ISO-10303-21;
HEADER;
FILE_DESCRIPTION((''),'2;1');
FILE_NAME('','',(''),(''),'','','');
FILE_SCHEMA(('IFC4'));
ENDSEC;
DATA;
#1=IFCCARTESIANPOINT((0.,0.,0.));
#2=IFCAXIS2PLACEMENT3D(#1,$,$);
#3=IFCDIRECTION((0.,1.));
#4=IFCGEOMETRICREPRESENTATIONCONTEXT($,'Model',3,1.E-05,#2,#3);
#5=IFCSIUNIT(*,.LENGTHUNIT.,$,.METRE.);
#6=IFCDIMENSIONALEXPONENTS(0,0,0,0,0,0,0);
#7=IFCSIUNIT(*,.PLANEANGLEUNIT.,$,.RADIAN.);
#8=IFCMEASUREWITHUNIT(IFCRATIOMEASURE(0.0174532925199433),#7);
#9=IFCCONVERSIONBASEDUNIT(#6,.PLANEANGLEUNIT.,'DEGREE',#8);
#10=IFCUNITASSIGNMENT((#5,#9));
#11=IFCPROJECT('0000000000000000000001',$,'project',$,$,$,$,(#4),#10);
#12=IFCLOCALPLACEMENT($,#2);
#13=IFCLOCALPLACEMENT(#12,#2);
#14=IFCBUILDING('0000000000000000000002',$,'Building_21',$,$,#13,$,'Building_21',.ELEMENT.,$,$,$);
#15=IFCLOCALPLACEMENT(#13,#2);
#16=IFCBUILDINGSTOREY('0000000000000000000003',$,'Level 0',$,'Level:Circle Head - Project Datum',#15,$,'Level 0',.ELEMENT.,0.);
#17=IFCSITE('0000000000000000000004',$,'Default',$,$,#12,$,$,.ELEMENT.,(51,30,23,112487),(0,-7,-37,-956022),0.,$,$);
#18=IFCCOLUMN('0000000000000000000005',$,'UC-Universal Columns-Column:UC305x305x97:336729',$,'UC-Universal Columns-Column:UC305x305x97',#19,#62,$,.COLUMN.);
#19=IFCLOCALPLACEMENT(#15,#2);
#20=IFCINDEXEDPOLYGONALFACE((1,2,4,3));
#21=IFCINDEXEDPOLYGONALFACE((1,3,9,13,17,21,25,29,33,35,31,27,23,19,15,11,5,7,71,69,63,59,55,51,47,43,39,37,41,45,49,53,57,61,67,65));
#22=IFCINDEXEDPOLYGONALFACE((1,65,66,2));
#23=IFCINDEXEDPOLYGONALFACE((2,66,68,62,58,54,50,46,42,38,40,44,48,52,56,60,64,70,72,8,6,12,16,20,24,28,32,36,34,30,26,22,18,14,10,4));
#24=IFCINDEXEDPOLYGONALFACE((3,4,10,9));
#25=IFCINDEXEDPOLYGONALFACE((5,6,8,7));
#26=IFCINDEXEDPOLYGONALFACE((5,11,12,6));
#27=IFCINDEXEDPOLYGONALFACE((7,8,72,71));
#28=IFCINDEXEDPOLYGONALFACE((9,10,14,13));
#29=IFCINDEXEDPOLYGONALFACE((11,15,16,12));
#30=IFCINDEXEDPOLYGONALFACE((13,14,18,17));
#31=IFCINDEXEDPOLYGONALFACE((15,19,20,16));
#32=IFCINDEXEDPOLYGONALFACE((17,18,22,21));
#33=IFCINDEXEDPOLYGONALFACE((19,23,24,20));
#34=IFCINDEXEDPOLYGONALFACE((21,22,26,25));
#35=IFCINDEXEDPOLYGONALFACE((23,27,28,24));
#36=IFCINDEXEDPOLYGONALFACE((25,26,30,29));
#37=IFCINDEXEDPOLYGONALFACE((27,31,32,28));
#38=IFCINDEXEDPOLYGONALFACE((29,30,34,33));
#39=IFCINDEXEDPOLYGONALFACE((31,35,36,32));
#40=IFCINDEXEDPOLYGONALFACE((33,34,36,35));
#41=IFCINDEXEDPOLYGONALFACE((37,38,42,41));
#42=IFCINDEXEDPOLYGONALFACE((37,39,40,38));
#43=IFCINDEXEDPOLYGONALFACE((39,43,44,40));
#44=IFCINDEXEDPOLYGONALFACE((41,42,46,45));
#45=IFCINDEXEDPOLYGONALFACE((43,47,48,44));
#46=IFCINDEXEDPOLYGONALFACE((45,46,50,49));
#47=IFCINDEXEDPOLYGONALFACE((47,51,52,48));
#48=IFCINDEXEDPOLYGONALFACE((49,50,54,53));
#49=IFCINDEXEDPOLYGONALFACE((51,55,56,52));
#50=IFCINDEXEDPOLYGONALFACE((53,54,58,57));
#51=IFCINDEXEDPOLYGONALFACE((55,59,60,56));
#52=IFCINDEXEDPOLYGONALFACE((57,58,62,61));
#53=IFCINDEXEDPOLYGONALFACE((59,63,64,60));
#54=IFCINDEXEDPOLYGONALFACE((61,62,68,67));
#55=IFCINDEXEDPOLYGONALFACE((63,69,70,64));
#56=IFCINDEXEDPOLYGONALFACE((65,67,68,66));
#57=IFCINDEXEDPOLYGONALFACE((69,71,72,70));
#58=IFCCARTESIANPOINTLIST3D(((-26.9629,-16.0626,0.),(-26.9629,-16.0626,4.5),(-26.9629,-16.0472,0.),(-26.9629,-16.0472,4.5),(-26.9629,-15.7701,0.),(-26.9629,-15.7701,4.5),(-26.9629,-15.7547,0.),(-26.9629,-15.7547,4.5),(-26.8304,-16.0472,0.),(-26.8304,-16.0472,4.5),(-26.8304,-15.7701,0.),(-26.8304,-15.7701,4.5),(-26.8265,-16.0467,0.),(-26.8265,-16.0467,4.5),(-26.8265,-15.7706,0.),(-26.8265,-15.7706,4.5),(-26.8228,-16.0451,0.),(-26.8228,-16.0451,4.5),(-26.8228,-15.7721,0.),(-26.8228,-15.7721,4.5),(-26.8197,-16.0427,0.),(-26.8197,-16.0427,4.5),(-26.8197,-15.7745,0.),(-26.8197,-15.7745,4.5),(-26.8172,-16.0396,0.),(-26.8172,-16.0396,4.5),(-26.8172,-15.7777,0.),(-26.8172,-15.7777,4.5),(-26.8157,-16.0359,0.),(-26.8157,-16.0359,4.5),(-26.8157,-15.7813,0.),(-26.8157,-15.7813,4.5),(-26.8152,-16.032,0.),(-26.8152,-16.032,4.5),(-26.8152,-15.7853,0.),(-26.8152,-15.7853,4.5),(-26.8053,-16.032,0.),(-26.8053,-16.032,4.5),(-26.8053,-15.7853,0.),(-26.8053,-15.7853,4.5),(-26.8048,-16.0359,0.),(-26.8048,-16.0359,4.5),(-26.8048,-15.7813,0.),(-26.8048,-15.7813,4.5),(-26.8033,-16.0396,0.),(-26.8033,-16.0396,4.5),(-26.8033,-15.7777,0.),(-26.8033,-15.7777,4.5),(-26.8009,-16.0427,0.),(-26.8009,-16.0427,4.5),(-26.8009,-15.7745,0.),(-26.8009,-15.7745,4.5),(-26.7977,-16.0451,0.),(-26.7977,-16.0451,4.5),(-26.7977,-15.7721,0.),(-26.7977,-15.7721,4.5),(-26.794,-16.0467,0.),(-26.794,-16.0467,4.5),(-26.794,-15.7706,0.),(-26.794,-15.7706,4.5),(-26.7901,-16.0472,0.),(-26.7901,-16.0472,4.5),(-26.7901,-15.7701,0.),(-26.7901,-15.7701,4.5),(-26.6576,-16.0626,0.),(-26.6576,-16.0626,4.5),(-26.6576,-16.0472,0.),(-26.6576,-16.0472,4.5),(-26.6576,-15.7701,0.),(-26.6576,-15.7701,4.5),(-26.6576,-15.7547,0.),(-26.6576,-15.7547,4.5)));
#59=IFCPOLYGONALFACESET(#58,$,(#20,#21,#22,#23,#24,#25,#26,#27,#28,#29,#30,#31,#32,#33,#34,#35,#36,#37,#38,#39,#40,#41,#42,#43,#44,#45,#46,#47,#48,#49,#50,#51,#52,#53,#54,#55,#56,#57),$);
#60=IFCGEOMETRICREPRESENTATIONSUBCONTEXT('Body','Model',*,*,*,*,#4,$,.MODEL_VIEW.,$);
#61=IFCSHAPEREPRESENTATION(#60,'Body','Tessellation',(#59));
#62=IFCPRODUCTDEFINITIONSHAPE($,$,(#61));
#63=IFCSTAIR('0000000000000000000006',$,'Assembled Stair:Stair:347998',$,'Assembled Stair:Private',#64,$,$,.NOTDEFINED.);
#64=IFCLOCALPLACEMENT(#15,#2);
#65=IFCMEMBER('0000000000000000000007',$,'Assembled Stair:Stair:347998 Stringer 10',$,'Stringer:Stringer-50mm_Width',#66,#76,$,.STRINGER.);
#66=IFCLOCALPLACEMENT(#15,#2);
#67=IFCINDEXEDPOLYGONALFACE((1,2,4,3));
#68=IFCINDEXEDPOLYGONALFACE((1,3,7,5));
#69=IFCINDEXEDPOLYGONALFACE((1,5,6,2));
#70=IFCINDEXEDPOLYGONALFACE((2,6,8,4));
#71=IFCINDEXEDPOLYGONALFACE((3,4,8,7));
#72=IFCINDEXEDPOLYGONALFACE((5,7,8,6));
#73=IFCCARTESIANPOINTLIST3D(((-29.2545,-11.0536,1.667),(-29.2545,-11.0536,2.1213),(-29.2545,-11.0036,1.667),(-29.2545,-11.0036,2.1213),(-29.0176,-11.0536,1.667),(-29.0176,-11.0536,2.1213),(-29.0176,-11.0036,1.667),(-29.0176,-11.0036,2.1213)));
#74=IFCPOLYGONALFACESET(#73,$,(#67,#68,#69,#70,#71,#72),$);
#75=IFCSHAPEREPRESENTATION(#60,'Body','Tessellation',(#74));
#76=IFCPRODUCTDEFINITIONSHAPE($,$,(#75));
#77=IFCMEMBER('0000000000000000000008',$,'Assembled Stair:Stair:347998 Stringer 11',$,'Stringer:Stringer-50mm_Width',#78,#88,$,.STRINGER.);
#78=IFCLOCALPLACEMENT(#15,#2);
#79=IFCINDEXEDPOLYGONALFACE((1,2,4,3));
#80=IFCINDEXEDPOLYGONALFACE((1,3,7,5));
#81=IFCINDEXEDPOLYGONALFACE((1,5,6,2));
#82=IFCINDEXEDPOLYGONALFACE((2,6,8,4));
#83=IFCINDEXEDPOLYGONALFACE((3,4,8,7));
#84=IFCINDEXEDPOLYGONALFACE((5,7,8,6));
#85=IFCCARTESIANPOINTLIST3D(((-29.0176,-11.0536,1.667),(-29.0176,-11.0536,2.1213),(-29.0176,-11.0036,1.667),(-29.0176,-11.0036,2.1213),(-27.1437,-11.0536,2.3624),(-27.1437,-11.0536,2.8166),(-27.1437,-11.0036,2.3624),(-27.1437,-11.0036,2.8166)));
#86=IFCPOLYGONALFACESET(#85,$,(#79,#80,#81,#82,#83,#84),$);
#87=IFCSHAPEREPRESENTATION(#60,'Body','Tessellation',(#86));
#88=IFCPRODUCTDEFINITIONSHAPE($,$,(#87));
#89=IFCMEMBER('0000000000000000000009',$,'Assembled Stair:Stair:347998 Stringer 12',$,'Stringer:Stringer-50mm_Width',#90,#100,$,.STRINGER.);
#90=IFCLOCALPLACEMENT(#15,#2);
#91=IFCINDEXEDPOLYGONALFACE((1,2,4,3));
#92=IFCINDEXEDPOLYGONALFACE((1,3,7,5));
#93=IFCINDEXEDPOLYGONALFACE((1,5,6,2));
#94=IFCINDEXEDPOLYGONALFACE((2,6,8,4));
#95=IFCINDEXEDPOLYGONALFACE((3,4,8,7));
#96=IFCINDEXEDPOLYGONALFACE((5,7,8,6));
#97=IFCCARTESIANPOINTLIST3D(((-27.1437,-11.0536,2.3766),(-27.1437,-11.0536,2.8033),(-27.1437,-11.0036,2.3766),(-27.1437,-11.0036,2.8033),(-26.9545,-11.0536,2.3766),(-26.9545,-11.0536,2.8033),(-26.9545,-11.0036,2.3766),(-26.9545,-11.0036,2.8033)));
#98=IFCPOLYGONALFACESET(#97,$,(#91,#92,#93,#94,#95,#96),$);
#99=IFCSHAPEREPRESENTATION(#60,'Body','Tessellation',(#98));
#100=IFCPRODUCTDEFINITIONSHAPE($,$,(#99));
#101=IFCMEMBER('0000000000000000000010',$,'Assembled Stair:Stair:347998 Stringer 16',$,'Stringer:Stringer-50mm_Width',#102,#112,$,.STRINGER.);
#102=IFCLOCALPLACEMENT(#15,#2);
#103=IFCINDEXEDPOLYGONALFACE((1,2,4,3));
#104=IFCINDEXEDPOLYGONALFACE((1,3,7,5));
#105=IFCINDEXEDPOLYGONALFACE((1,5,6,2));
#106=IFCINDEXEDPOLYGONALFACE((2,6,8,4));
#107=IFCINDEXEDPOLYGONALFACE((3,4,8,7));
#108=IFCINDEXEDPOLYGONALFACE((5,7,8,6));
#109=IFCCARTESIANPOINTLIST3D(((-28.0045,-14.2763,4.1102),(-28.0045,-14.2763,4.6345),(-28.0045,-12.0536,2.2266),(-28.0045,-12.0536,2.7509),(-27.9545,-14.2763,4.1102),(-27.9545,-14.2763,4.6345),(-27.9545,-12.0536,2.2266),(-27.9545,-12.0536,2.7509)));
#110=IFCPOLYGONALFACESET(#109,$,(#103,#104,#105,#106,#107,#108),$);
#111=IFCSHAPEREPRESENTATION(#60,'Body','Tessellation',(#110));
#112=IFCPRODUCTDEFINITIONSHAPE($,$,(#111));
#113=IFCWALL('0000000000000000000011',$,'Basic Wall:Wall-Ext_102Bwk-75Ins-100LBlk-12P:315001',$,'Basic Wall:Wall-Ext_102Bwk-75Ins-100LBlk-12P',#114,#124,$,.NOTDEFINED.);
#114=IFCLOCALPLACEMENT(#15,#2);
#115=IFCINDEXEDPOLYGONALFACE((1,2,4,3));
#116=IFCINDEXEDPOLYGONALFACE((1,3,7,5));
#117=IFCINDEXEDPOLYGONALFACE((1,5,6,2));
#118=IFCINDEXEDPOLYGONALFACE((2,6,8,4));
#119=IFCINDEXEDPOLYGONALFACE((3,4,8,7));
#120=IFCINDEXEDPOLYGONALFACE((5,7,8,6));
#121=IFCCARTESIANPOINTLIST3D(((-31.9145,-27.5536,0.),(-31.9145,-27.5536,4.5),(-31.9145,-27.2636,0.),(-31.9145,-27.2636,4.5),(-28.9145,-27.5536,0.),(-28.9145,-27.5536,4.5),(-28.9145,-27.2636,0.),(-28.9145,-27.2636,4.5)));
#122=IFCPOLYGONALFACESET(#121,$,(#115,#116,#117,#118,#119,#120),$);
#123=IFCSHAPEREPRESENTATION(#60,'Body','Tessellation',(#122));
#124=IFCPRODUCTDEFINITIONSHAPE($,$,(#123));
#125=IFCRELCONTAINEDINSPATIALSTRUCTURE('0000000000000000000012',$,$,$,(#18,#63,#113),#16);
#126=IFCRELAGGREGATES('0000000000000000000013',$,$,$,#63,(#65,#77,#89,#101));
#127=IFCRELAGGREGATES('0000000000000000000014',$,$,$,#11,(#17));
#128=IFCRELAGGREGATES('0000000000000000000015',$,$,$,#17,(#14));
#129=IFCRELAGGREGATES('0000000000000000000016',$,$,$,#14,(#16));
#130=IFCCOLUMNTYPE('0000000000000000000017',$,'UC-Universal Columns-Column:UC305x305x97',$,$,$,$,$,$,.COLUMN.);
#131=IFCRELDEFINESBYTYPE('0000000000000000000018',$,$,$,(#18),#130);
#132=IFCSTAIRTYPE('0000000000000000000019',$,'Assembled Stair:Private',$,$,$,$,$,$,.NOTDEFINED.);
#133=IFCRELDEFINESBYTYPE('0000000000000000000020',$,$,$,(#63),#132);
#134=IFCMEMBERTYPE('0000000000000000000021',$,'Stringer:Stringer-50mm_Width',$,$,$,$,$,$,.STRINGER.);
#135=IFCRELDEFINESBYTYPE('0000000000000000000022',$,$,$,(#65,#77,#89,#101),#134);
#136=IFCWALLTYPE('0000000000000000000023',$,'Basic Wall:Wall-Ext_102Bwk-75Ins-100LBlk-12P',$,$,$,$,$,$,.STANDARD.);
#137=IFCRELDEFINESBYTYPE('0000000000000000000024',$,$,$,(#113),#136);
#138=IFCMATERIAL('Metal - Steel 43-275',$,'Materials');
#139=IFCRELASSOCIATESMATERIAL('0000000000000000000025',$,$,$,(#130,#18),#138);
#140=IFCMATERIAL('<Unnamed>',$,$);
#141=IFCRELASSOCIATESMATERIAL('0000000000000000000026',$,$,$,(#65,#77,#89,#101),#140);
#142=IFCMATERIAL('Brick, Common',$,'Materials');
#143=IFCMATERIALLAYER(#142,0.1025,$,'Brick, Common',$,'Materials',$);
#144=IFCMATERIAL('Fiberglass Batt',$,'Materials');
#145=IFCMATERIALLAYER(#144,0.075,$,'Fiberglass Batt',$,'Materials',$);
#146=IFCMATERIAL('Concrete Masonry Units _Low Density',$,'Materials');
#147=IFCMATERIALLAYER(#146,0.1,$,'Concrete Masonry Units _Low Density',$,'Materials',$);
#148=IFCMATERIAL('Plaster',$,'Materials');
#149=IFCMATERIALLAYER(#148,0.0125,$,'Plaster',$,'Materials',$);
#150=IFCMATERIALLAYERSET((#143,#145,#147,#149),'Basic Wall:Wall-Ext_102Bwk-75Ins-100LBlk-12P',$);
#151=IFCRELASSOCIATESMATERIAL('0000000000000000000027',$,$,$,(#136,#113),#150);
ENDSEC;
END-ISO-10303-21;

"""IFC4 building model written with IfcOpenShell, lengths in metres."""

from ifc_helpers import new_model, entity, si_unit, converted_unit, direction, frame, frame_2d, origin, place, context, subcontext, project, spatial, polyline, circle_curve, parameter, trimmed, segment, composite_curve, rectangle, i_section, outline, extrude, source, transform, mapped, material, layer, layer_set, layer_usage, material_profile, profile_set, profile_usage, type_object, type_shapes, element, aggregate, save


model = new_model("IFC4")

# Units and contexts
model_context = context("Model", 3, precision=1e-05, world=origin(), true_north=direction((0.0, 1.0)))
body_context = subcontext(model_context, "Body", "Model", "MODEL_VIEW")
ifc_project = project(units=[si_unit("LENGTHUNIT", "METRE"), converted_unit("PLANEANGLEUNIT", "DEGREE", entity("IfcRatioMeasure", 0.0174532925199433), si_unit("PLANEANGLEUNIT", "RADIAN"), dimensions=[0, 0, 0, 0, 0, 0, 0])], contexts=[model_context])

# Site, building, storey
site_placement = place(None, origin())
site = spatial("IfcSite", under=ifc_project, at=site_placement, Name="Default", CompositionType="ELEMENT", RefLatitude=(51, 30, 23, 112487), RefLongitude=(0, -7, -37, -956022), RefElevation=0.0)
building_placement = place(site_placement, origin())
building = spatial("IfcBuilding", under=site, at=building_placement, Name="Building_21", LongName="Building_21", CompositionType="ELEMENT")
storey_placement = place(building_placement, origin())
storey = spatial("IfcBuildingStorey", under=building, at=storey_placement, Name="Level 0", ObjectType="Level:Circle Head - Project Datum", LongName="Level 0", CompositionType="ELEMENT", Elevation=0.0)

# Column
ifc_material_1 = material(Name="Metal - Steel 43-275", Category="Materials")
ifc_material_profile_1 = material_profile(ifc_material_1, outline(composite_curve([segment(polyline([(-0.1527, 0.154, 0.0), (0.1527, 0.154, 0.0)]), True, "CONTINUOUS"), segment(polyline([(0.1527, 0.154, 0.0), (0.1527, 0.1386, 0.0)]), True, "CONTINUOUS"), segment(polyline([(0.1527, 0.1386, 0.0), (0.0201, 0.1386, 0.0)]), True, "CONTINUOUS"), segment(trimmed(circle_curve(frame((0.0201, 0.1234, 0.0)), 0.0152), [parameter(90.0)], [parameter(180.0)], True, "PARAMETER"), True, "CONTINUOUS"), segment(polyline([(0.0049, 0.1234, 0.0), (0.0049, -0.1234, 0.0)]), True, "CONTINUOUS"), segment(trimmed(circle_curve(frame((0.0201, -0.1234, 0.0)), 0.0152), [parameter(180.0)], [parameter(270.0)], True, "PARAMETER"), True, "CONTINUOUS"), segment(polyline([(0.0201, -0.1386, 0.0), (0.1527, -0.1386, 0.0)]), True, "CONTINUOUS"), segment(polyline([(0.1527, -0.1386, 0.0), (0.1527, -0.154, 0.0)]), True, "CONTINUOUS"), segment(polyline([(0.1527, -0.154, 0.0), (-0.1527, -0.154, 0.0)]), True, "CONTINUOUS"), segment(polyline([(-0.1527, -0.154, 0.0), (-0.1527, -0.1386, 0.0)]), True, "CONTINUOUS"), segment(polyline([(-0.1527, -0.1386, 0.0), (-0.0201, -0.1386, 0.0)]), True, "CONTINUOUS"), segment(trimmed(circle_curve(frame((-0.0201, -0.1234, 0.0)), 0.0152), [parameter(270.0)], [parameter(0.0)], True, "PARAMETER"), True, "CONTINUOUS"), segment(polyline([(-0.0049, -0.1234, 0.0), (-0.005, 0.1234, 0.0)]), True, "CONTINUOUS"), segment(trimmed(circle_curve(frame((-0.0201, 0.1234, 0.0)), 0.0152), [parameter(0.0)], [parameter(90.0)], True, "PARAMETER"), True, "CONTINUOUS"), segment(polyline([(-0.0201, 0.1386, 0.0), (-0.1527, 0.1386, 0.0)]), True, "CONTINUOUS"), segment(polyline([(-0.1527, 0.1386, 0.0), (-0.1527, 0.154, 0.0)]), True, "CONTINUOUS")], self_intersect=False), kind="CURVE"), Name="UC305x305x97")
ifc_material_profile_2 = material_profile(ifc_material_1, outline(composite_curve([segment(polyline([(0.1527, 0.154, 0.0), (0.1527, 0.1386, 0.0)]), True, "CONTINUOUS"), segment(polyline([(0.1527, 0.1386, 0.0), (0.0049, 0.1386, 0.0)]), True, "CONTINUOUS"), segment(polyline([(0.0049, 0.1386, 0.0), (0.0049, -0.1386, 0.0)]), True, "CONTINUOUS"), segment(polyline([(0.0049, -0.1386, 0.0), (0.1527, -0.1386, 0.0)]), True, "CONTINUOUS"), segment(polyline([(0.1527, -0.1386, 0.0), (0.1527, -0.154, 0.0)]), True, "CONTINUOUS"), segment(polyline([(0.1527, -0.154, 0.0), (-0.1527, -0.154, 0.0)]), True, "CONTINUOUS"), segment(polyline([(-0.1527, -0.154, 0.0), (-0.1527, -0.1386, 0.0)]), True, "CONTINUOUS"), segment(polyline([(-0.1527, -0.1386, 0.0), (-0.005, -0.1386, 0.0)]), True, "CONTINUOUS"), segment(polyline([(-0.005, -0.1386, 0.0), (-0.005, 0.1386, 0.0)]), True, "CONTINUOUS"), segment(polyline([(-0.005, 0.1386, 0.0), (-0.1527, 0.1386, 0.0)]), True, "CONTINUOUS"), segment(polyline([(-0.1527, 0.1386, 0.0), (-0.1527, 0.154, 0.0)]), True, "CONTINUOUS"), segment(polyline([(-0.1527, 0.154, 0.0), (0.1527, 0.154, 0.0)]), True, "CONTINUOUS")], self_intersect=False), kind="CURVE"), Name="UC305x305x97")
ifc_profile_set = profile_set([ifc_material_profile_1, ifc_material_profile_2], Name="UC305x305x97")
column_type = type_object("IfcColumnType", Name="UC-Universal Columns-Column:UC305x305x97", PredefinedType="COLUMN", material=ifc_profile_set)
shared_shape = source(origin(), body_context, "Body", "SweptSolid", [
    extrude(i_section(OverallWidth=0.3053, OverallDepth=0.3079, WebThickness=0.0099, FlangeThickness=0.0154, FilletRadius=0.0152, at=frame_2d((0.0, 0.0), x_axis=(0.0, 1.0))), frame((0.0, 0.0, 0.0), z_axis=(0.0, 0.0, 1.0), x_axis=(0.0, -1.0, 0.0)), (0.0, 0.0, 1.0), 4.5),
])
type_shapes(column_type, [shared_shape])
ifc_profile_usage_1 = profile_usage(ifc_profile_set)
column_1_placement = place(storey_placement, frame((-26.8103, -15.9086, 0.0)))
element("IfcColumn", 1, at=column_1_placement, inside=storey, type_object=column_type, material=ifc_profile_usage_1, Name="UC-Universal Columns-Column:UC305x305x97:336729", ObjectType="UC-Universal Columns-Column:UC305x305x97", PredefinedType="COLUMN", context=body_context, shape_type="MappedRepresentation", body=[
    mapped(shared_shape, transform((0.0, 0.0, 0.0), scale=1.0)),
])

# Stair, members
stair_type = type_object("IfcStairType", Name="Assembled Stair:Private", PredefinedType="NOTDEFINED")
stair_placement = place(storey_placement, origin())
stair = element("IfcStair", 2, at=stair_placement, inside=storey, type_object=stair_type, Name="Assembled Stair:Stair:347998", ObjectType="Assembled Stair:Private", PredefinedType="NOTDEFINED")
ifc_material_2 = material(Name="<Unnamed>")
member_type = type_object("IfcMemberType", Name="Stringer:Stringer-50mm_Width", PredefinedType="STRINGER")
member_1_placement = place(stair_placement, frame((-29.2545, -11.0536, 1.667)))
member_1 = element("IfcMember", 3, at=member_1_placement, type_object=member_type, material=ifc_material_2, Name="Assembled Stair:Stair:347998 Stringer 10", ObjectType="Stringer:Stringer-50mm_Width", PredefinedType="STRINGER", context=body_context, shape_type="SweptSolid", body=[
    extrude(rectangle(XDim=0.2368, YDim=0.05, at=frame_2d((0.0, 0.0), x_axis=(1.0, 0.0))), frame((0.1184, 0.025, 0.0)), (0.0, 0.0, 1.0), 0.4543),
])
member_2_placement = place(stair_placement, frame((-29.0176, -11.0536, 1.667)))
member_2 = element("IfcMember", 4, at=member_2_placement, type_object=member_type, material=ifc_material_2, Name="Assembled Stair:Stair:347998 Stringer 11", ObjectType="Stringer:Stringer-50mm_Width", PredefinedType="STRINGER", context=body_context, shape_type="SweptSolid", body=[
    extrude(outline(polyline([(-0.9204, -0.213), (1.0784, -0.213), (0.9204, 0.213), (-1.0784, 0.213), (-0.9204, -0.213)])), frame((0.937, 0.0, 0.5748), z_axis=(0.0, 1.0, 0.0), x_axis=(0.937533, 0.0, 0.347896)), (0.0, 0.0, 1.0), 0.05),
])
member_3_placement = place(stair_placement, frame((-27.1437, -11.0536, 2.3766)))
member_3 = element("IfcMember", 5, at=member_3_placement, type_object=member_type, material=ifc_material_2, Name="Assembled Stair:Stair:347998 Stringer 12", ObjectType="Stringer:Stringer-50mm_Width", PredefinedType="STRINGER", context=body_context, shape_type="SweptSolid", body=[
    extrude(rectangle(XDim=0.1893, YDim=0.05, at=frame_2d((0.0, 0.0), x_axis=(1.0, 0.0))), frame((0.0946, 0.025, 0.0)), (0.0, 0.0, 1.0), 0.4267),
])
member_4_placement = place(stair_placement, frame((-28.0045, -14.2763, 2.2266)))
member_4 = element("IfcMember", 6, at=member_4_placement, type_object=member_type, material=ifc_material_2, Name="Assembled Stair:Stair:347998 Stringer 16", ObjectType="Stringer:Stringer-50mm_Width", PredefinedType="STRINGER", context=body_context, shape_type="SweptSolid", body=[
    extrude(outline(polyline([(-1.2872, -0.2), (1.6262, -0.2), (1.2872, 0.2), (-1.6262, 0.2), (-1.2872, -0.2)])), frame((0.0, 1.1113, 1.204), z_axis=(1.0, 0.0, 0.0), x_axis=(0.0, -0.762891, 0.646527)), (0.0, 0.0, 1.0), 0.05),
])
aggregate(stair, [member_1, member_2, member_3, member_4])

# Wall
ifc_material_3 = material(Name="Brick, Common", Category="Materials")
ifc_layer_1 = layer(ifc_material_3, 0.1025, Name="Brick, Common", Category="Materials")
ifc_material_4 = material(Name="Fiberglass Batt", Category="Materials")
ifc_layer_2 = layer(ifc_material_4, 0.075, Name="Fiberglass Batt", Category="Materials")
ifc_material_5 = material(Name="Concrete Masonry Units _Low Density", Category="Materials")
ifc_layer_3 = layer(ifc_material_5, 0.1, Name="Concrete Masonry Units _Low Density", Category="Materials")
ifc_material_6 = material(Name="Plaster", Category="Materials")
ifc_layer_4 = layer(ifc_material_6, 0.0125, Name="Plaster", Category="Materials")
ifc_layer_set_1 = layer_set([ifc_layer_1, ifc_layer_2, ifc_layer_3, ifc_layer_4], Name="Basic Wall:Wall-Ext_102Bwk-75Ins-100LBlk-12P")
ifc_layer_usage_1 = layer_usage(ifc_layer_set_1, "AXIS2", "NEGATIVE", 0.145)
wall_type_1 = type_object("IfcWallType", Name="Basic Wall:Wall-Ext_102Bwk-75Ins-100LBlk-12P", PredefinedType="STANDARD", material=ifc_layer_set_1)
wall_1_placement = place(storey_placement, frame((-31.9145, -27.4086, 0.0)))
element("IfcWall", 7, at=wall_1_placement, inside=storey, type_object=wall_type_1, material=ifc_layer_usage_1, Name="Basic Wall:Wall-Ext_102Bwk-75Ins-100LBlk-12P:315001", ObjectType="Basic Wall:Wall-Ext_102Bwk-75Ins-100LBlk-12P", PredefinedType="NOTDEFINED", context=body_context, shape_type="SweptSolid", body=[
    extrude(rectangle(XDim=3.0, YDim=0.29, at=frame_2d((1.5, 0.0), x_axis=(-1.0, 0.0))), origin(), (0.0, 0.0, 1.0), 4.5),
])

save(model, "model.ifc")
